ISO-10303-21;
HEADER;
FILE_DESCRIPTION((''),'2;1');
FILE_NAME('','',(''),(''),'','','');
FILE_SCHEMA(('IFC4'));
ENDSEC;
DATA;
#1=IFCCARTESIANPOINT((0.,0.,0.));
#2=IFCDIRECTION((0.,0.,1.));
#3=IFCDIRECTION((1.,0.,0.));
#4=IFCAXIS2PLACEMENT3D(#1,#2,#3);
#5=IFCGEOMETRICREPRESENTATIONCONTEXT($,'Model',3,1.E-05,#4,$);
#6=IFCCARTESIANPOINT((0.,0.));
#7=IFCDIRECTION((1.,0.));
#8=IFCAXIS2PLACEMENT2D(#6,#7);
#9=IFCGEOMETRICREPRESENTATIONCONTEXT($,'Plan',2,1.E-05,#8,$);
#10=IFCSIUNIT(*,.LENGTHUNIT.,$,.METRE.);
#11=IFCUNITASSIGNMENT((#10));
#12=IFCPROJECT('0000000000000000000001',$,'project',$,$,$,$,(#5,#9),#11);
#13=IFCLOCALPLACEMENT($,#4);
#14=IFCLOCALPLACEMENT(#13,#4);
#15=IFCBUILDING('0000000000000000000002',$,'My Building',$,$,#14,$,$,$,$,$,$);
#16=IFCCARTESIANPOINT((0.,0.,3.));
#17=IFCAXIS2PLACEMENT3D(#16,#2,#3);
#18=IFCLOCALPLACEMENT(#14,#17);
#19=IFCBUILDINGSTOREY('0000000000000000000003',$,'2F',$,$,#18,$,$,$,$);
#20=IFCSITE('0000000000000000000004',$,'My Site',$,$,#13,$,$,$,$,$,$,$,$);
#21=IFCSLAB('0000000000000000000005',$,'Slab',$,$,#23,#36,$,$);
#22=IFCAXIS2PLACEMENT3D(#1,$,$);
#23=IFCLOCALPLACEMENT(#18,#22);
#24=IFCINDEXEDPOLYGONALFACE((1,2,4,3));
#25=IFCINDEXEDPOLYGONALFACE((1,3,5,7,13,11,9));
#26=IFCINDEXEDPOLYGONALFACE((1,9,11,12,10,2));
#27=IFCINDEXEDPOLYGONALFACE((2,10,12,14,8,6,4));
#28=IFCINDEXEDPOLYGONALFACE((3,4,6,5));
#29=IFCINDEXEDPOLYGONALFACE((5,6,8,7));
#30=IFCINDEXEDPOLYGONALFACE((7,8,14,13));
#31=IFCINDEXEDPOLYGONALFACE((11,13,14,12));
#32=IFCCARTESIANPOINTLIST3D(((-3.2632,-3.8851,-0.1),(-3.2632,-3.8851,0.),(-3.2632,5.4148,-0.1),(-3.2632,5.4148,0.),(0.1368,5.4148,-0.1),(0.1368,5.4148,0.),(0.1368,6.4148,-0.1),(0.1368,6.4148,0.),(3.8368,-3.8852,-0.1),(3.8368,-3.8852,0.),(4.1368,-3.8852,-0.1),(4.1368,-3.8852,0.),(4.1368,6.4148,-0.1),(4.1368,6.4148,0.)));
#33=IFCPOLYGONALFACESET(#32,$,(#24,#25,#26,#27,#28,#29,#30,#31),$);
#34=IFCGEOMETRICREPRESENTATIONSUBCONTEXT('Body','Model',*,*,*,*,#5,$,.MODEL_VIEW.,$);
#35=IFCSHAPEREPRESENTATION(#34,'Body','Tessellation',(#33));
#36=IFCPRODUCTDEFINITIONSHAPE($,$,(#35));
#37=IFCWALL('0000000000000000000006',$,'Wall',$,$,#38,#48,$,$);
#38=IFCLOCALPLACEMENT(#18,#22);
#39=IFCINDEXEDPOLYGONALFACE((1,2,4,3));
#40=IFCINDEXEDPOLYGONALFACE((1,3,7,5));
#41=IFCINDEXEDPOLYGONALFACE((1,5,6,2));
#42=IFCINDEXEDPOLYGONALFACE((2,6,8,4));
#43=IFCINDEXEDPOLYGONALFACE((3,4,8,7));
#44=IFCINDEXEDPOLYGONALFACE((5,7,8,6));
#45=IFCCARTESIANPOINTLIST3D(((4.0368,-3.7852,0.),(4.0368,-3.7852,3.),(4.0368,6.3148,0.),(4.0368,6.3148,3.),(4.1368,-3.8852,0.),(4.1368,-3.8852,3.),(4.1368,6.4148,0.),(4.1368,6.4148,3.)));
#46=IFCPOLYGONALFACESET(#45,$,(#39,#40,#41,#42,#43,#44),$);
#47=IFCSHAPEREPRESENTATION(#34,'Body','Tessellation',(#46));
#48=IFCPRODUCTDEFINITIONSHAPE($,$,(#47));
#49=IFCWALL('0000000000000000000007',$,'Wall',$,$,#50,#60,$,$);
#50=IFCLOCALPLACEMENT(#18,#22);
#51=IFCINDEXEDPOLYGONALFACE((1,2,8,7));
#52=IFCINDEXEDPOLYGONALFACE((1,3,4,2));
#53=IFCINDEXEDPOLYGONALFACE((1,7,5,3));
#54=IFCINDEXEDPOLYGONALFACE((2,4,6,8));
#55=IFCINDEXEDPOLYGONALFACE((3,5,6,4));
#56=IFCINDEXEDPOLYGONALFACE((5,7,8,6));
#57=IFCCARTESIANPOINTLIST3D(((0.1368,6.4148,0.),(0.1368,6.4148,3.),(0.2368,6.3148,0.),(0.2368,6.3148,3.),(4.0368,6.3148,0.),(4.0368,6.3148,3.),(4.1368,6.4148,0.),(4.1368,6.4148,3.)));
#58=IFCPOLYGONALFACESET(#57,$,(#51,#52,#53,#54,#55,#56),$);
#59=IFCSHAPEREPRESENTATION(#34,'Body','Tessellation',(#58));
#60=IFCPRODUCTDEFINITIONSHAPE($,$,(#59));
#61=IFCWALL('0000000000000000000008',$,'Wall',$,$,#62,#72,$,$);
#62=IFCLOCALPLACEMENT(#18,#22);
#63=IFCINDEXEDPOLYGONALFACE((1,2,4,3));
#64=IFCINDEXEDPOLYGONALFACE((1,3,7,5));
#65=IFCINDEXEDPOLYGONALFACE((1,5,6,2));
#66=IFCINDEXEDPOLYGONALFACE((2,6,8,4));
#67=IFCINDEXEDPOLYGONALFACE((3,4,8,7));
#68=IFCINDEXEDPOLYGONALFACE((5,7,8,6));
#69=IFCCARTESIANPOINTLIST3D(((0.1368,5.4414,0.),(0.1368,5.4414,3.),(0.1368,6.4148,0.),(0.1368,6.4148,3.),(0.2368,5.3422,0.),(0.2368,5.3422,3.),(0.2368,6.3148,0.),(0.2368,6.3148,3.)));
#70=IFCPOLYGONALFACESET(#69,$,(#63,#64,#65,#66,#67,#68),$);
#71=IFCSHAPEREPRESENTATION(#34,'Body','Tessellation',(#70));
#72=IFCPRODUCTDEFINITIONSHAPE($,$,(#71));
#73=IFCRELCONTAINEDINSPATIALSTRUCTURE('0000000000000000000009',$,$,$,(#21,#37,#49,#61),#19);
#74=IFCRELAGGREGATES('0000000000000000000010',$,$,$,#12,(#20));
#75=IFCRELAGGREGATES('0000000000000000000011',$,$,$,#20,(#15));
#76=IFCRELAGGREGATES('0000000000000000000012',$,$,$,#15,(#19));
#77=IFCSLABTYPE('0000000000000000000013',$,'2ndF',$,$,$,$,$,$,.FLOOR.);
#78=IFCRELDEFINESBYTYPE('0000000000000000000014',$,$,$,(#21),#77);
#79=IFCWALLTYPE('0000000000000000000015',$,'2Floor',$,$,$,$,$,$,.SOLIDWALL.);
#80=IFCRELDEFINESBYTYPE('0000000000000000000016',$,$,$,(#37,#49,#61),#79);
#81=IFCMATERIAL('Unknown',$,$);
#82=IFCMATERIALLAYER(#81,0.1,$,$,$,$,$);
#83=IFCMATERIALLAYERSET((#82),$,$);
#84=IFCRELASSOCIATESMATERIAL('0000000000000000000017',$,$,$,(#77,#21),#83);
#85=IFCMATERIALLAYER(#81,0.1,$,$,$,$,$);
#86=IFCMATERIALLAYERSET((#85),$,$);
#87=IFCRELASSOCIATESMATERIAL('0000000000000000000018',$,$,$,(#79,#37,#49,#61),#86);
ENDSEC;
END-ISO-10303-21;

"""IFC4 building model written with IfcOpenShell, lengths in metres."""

from ifc_helpers import new_model, si_unit, frame, origin_with_axes, origin_2d_with_axis, place, context, subcontext, project, spatial, line, indexed_curve, outline, extrude, material, layer, layer_set, layer_usage, type_object, element, save


model = new_model("IFC4")

# Units and contexts
model_context = context("Model", 3, precision=1e-05, world=origin_with_axes())
plan_context = context("Plan", 2, precision=1e-05, world=origin_2d_with_axis())
body_context_1 = subcontext(model_context, "Body", "Model", "MODEL_VIEW")
ifc_project = project(units=[si_unit("LENGTHUNIT", "METRE")], contexts=[model_context, plan_context])

# Site, building, storey
site_placement = place(None, origin_with_axes())
site = spatial("IfcSite", under=ifc_project, at=site_placement, Name="My Site")
building_placement = place(site_placement, origin_with_axes())
building = spatial("IfcBuilding", under=site, at=building_placement, Name="My Building")
storey_placement = place(building_placement, frame((0.0, 0.0, 3.0), z_axis=(0.0, 0.0, 1.0), x_axis=(1.0, 0.0, 0.0)))
storey = spatial("IfcBuildingStorey", under=building, at=storey_placement, Name="2F")

# Slab
ifc_material = material(Name="Unknown")
ifc_layer_1 = layer(ifc_material, 0.1)
ifc_layer_set_1 = layer_set([ifc_layer_1])
ifc_layer_usage_1 = layer_usage(ifc_layer_set_1, "AXIS3", "POSITIVE", -0.1)
slab_type = type_object("IfcSlabType", Name="2ndF", PredefinedType="FLOOR", material=ifc_layer_set_1)
slab_placement = place(storey_placement, frame((3.8368, -3.8852, 0.0), z_axis=(0.0, 0.0, 1.0), x_axis=(1.0, 0.0, 0.0)))
element("IfcSlab", 1, at=slab_placement, inside=storey, type_object=slab_type, material=ifc_layer_usage_1, Name="Slab", context=body_context_1, shape_type="SweptSolid", body=[
    extrude(outline(indexed_curve([(0.0, 0.0), (0.3, 0.0), (0.3, 10.3), (-3.7, 10.3), (-3.7, 9.3), (-7.1, 9.3), (-7.1, 0.0), (0.0, 0.0)])), frame((0.0, 0.0, -0.1), z_axis=(0.0, 0.0, 1.0), x_axis=(1.0, 0.0, 0.0)), (0.0, 0.0, 1.0), 0.1),
])

# Walls
ifc_layer_2 = layer(ifc_material, 0.1)
ifc_layer_set_2 = layer_set([ifc_layer_2])
ifc_layer_usage_2 = layer_usage(ifc_layer_set_2, "AXIS2", "POSITIVE", 0.0)
wall_type = type_object("IfcWallType", Name="2Floor", PredefinedType="SOLIDWALL", material=ifc_layer_set_2)
wall_1_placement = place(storey_placement, frame((4.1368, -3.8852, 0.0), z_axis=(0.0, 0.0, 1.0), x_axis=(0.0, 1.0, 0.0)))
element("IfcWall", 2, at=wall_1_placement, inside=storey, type_object=wall_type, material=ifc_layer_usage_2, Name="Wall", context=body_context_1, shape_type="SweptSolid", body=[
    extrude(outline(indexed_curve([(0.0, 0.0), (0.1, 0.1), (10.2, 0.1), (10.3, 0.0)], segments=[line(1, 2, 3, 4, 1)])), origin_with_axes(), (0.0, 0.0, 1.0), 3.0),
])
ifc_layer_usage_3 = layer_usage(ifc_layer_set_2, "AXIS2", "POSITIVE", 0.0)
wall_2_placement = place(storey_placement, frame((4.1368, 6.4148, 0.0), z_axis=(0.0, 0.0, 1.0), x_axis=(-1.0, 0.0, 0.0)))
element("IfcWall", 3, at=wall_2_placement, inside=storey, type_object=wall_type, material=ifc_layer_usage_3, Name="Wall", context=body_context_1, shape_type="SweptSolid", body=[
    extrude(outline(indexed_curve([(0.0, 0.0), (0.1, 0.1), (3.9, 0.1), (4.0, 0.0)], segments=[line(1, 2, 3, 4, 1)])), origin_with_axes(), (0.0, 0.0, 1.0), 3.0),
])
ifc_layer_usage_4 = layer_usage(ifc_layer_set_2, "AXIS2", "POSITIVE", 0.0)
wall_3_placement = place(storey_placement, frame((0.1368, 6.4148, 0.0), z_axis=(0.0, 0.0, 1.0), x_axis=(0.0, -1.0, 0.0)))
element("IfcWall", 4, at=wall_3_placement, inside=storey, type_object=wall_type, material=ifc_layer_usage_4, Name="Wall", context=body_context_1, shape_type="SweptSolid", body=[
    extrude(outline(indexed_curve([(0.0, 0.0), (0.1, 0.1), (1.0727, 0.1), (0.9734, 0.0)], segments=[line(1, 2, 3, 4, 1)])), origin_with_axes(), (0.0, 0.0, 1.0), 3.0),
])

save(model, "model.ifc")
